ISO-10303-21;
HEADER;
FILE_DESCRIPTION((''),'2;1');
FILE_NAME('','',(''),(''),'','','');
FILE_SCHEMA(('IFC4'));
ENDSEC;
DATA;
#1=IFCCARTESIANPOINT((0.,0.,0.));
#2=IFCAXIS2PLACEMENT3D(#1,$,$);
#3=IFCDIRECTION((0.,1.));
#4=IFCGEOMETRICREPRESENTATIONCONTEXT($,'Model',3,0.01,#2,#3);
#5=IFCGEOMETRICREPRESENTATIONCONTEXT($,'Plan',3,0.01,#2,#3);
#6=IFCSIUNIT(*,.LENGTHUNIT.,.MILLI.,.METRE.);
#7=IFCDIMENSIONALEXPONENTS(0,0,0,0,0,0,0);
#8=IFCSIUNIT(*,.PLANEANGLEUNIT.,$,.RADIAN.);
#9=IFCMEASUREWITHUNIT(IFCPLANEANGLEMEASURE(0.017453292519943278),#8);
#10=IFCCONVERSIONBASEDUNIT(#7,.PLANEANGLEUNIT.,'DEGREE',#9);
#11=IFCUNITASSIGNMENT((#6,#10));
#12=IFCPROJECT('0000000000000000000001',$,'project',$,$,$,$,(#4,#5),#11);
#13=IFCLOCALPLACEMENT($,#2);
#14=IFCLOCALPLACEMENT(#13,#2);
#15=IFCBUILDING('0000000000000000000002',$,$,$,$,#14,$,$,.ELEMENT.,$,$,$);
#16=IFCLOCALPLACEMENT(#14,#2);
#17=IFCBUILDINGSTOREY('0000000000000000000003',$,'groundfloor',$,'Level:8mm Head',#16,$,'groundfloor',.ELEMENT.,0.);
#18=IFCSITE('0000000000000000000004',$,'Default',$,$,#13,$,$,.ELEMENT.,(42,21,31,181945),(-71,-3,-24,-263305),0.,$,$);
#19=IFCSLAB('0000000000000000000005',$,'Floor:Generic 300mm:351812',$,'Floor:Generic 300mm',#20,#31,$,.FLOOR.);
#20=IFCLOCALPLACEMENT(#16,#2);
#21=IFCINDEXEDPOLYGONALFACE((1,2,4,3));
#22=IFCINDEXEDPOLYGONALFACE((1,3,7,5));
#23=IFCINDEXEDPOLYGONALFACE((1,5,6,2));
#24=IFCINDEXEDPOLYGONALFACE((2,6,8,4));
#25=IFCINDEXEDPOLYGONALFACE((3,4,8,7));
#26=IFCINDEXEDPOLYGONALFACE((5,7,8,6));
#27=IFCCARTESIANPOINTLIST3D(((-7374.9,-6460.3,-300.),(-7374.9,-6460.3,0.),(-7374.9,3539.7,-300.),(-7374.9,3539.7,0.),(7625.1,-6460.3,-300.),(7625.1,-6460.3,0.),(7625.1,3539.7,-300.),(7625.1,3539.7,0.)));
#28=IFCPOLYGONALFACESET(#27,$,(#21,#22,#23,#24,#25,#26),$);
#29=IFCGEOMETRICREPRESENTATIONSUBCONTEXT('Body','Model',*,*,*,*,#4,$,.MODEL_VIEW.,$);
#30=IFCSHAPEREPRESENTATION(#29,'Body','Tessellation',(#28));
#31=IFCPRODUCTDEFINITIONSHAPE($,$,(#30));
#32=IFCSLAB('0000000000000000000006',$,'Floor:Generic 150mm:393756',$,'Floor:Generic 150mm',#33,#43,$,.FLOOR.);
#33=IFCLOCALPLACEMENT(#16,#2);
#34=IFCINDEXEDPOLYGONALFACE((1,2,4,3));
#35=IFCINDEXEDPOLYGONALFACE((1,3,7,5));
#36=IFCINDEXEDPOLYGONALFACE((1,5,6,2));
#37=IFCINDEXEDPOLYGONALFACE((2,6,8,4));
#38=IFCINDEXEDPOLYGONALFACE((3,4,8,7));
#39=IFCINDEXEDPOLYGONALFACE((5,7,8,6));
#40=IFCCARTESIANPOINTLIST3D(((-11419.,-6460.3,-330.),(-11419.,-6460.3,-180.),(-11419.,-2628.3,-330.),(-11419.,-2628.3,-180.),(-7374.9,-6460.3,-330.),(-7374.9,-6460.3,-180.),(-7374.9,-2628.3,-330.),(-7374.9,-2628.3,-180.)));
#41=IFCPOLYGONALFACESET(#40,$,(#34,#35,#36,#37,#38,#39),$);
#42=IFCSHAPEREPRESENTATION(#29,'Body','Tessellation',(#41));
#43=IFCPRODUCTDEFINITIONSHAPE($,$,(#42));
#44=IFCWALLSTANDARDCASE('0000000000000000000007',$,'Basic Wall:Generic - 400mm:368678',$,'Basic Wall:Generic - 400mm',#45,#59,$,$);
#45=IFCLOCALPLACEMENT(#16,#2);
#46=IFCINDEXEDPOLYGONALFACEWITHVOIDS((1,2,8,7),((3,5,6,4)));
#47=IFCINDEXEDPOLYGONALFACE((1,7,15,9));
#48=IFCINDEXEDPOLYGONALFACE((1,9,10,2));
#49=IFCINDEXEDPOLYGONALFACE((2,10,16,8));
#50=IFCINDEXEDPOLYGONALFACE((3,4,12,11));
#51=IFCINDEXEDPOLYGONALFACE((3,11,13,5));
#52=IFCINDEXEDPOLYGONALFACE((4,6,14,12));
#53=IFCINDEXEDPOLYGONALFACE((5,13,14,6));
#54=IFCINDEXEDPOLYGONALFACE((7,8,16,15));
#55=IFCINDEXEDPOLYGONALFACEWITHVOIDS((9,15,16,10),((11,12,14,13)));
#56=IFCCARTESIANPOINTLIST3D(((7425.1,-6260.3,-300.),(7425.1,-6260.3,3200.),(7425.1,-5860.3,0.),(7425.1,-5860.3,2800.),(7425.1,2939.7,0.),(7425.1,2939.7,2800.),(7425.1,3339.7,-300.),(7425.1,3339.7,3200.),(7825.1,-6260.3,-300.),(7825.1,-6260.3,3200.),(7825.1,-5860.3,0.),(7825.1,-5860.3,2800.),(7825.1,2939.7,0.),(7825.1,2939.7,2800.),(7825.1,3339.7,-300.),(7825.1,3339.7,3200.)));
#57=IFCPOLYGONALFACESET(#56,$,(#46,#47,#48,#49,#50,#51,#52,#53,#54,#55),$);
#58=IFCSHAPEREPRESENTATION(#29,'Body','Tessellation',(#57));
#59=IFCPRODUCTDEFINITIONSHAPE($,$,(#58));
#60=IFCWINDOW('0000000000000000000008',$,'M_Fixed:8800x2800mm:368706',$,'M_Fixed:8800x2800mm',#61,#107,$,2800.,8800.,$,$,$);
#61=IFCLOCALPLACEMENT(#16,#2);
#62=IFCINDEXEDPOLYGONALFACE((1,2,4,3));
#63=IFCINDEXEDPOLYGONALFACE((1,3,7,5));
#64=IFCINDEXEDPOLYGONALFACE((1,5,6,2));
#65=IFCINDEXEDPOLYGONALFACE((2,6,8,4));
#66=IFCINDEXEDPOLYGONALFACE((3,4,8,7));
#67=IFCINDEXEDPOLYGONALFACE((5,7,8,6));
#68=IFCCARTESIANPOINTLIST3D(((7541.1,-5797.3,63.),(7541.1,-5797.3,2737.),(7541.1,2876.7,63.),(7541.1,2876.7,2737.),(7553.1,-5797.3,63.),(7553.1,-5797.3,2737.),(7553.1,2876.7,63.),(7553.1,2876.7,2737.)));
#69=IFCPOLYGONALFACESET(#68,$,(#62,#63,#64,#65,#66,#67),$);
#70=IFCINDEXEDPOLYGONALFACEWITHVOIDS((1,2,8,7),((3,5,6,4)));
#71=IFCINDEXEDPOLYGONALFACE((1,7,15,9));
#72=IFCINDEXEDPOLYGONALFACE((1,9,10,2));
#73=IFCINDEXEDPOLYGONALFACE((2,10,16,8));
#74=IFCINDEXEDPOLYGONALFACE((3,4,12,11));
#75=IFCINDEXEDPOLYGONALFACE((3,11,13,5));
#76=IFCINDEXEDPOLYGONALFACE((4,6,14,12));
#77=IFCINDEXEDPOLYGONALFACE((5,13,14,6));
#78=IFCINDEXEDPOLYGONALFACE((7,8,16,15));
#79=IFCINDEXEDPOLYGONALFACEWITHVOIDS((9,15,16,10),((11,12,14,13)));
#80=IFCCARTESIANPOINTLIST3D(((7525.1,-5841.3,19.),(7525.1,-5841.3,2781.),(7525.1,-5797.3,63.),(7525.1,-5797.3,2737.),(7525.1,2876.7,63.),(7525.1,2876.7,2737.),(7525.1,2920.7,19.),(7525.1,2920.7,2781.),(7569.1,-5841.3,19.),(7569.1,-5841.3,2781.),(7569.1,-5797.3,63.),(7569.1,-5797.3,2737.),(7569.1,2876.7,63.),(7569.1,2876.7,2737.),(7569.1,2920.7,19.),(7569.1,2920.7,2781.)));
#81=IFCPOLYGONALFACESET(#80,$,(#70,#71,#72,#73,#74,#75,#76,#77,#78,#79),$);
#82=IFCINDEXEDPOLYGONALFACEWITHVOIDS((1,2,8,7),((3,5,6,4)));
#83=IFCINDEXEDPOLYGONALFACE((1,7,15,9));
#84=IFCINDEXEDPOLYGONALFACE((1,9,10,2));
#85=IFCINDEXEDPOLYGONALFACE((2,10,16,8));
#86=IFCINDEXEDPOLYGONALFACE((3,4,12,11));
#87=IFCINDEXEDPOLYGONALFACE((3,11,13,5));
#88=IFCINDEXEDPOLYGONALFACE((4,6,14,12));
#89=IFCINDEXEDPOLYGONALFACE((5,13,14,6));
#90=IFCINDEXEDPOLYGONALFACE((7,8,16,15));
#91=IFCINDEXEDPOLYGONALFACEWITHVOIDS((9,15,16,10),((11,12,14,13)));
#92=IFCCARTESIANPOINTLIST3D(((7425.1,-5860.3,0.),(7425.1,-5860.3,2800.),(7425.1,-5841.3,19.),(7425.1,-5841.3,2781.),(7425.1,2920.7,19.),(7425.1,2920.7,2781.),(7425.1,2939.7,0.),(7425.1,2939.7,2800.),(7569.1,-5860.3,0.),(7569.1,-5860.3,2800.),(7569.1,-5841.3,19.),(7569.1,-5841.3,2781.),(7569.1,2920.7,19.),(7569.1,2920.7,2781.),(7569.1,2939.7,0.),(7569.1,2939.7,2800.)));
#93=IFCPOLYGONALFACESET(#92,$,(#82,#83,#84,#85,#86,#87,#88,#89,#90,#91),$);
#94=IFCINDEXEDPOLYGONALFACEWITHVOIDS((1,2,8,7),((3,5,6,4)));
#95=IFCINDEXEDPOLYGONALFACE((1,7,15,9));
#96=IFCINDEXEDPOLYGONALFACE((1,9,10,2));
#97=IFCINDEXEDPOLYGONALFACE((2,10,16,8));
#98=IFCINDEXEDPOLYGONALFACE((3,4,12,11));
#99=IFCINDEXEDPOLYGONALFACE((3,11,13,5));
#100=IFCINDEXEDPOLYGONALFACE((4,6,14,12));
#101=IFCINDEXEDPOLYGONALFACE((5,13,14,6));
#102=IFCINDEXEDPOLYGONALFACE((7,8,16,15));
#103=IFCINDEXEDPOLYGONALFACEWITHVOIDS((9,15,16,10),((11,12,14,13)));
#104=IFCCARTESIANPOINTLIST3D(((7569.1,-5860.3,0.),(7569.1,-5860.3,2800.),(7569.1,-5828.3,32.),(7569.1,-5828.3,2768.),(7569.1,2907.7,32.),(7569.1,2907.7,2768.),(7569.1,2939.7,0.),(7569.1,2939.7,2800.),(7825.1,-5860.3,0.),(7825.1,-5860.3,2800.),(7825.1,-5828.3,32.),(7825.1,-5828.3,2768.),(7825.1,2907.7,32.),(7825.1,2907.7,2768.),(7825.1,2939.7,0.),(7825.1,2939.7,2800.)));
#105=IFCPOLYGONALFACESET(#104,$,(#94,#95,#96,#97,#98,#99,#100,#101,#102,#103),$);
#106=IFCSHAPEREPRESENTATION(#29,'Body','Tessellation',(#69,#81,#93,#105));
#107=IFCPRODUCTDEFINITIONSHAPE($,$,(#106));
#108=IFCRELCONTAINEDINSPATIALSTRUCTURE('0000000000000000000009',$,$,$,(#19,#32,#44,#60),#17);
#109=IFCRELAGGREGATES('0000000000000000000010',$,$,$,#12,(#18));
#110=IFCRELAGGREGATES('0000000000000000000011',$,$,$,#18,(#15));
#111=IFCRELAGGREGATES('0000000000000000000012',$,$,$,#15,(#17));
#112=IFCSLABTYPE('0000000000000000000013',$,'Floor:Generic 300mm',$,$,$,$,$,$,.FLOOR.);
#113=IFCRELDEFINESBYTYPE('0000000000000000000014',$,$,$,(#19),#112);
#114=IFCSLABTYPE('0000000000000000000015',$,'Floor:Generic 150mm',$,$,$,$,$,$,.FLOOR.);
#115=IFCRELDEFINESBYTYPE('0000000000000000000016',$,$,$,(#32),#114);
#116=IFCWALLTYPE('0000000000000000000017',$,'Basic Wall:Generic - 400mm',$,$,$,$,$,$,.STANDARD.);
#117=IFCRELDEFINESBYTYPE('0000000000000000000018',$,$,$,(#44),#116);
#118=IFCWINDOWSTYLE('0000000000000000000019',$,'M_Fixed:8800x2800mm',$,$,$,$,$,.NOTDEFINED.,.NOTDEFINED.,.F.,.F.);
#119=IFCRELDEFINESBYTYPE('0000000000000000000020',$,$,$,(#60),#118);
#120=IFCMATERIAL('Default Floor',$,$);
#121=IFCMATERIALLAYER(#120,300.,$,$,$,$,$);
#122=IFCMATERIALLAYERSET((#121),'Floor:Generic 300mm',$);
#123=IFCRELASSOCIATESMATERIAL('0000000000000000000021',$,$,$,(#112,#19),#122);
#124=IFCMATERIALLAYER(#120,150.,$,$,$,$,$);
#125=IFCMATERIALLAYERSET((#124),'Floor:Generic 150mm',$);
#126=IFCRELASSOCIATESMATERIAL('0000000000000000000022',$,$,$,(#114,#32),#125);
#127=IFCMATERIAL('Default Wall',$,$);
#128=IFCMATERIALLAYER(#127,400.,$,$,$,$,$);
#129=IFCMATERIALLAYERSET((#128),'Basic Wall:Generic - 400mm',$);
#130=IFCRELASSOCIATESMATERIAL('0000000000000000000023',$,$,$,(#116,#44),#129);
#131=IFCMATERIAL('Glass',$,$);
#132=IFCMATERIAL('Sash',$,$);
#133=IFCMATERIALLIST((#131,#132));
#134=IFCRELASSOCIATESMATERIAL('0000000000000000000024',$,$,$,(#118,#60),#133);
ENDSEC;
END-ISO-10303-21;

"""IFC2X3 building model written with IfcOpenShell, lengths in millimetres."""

from ifc_helpers import new_model, entity, si_unit, converted_unit, direction, frame, frame_2d, origin, origin_2d_with_axis, place, context, subcontext, project, spatial, polyline, rectangle, outline, extrude, source, transform, mapped, material, material_list, layer, layer_set, layer_usage, type_object, type_shapes, element, fill, save


model = new_model("IFC2X3")

# Units and contexts
model_context = context("Model", 3, precision=0.01, world=origin(), true_north=direction((0.0, 1.0)))
plan_context = context("Plan", 3, precision=0.01, world=origin(), true_north=direction((0.0, 1.0)))
body_context = subcontext(model_context, "Body", "Model", "MODEL_VIEW")
ifc_project = project(units=[si_unit("LENGTHUNIT", "METRE", prefix="MILLI"), converted_unit("PLANEANGLEUNIT", "DEGREE", entity("IfcPlaneAngleMeasure", 0.017453292519943278), si_unit("PLANEANGLEUNIT", "RADIAN"), dimensions=[0, 0, 0, 0, 0, 0, 0])], contexts=[model_context, plan_context])

# Site, building, storey
site_placement = place(None, origin())
site = spatial("IfcSite", under=ifc_project, at=site_placement, Name="Default", CompositionType="ELEMENT", RefLatitude=(42, 21, 31, 181945), RefLongitude=(-71, -3, -24, -263305), RefElevation=0.0)
building_placement = place(site_placement, origin())
building = spatial("IfcBuilding", under=site, at=building_placement, CompositionType="ELEMENT")
storey_placement = place(building_placement, origin())
storey = spatial("IfcBuildingStorey", under=building, at=storey_placement, Name="groundfloor", ObjectType="Level:8mm Head", LongName="groundfloor", CompositionType="ELEMENT", Elevation=0.0)

# Slabs
ifc_material_1 = material(Name="Default Floor")
ifc_layer_1 = layer(ifc_material_1, 300.0)
ifc_layer_set_1 = layer_set([ifc_layer_1], Name="Floor:Generic 300mm")
ifc_layer_usage_1 = layer_usage(ifc_layer_set_1, "AXIS3", "POSITIVE", 0.0)
slab_type_1 = type_object("IfcSlabType", Name="Floor:Generic 300mm", PredefinedType="FLOOR", material=ifc_layer_set_1)
slab_1_placement = place(storey_placement, origin())
element("IfcSlab", 1, at=slab_1_placement, inside=storey, type_object=slab_type_1, material=ifc_layer_usage_1, Name="Floor:Generic 300mm:351812", ObjectType="Floor:Generic 300mm", PredefinedType="FLOOR", context=body_context, shape_type="SweptSolid", body=[
    extrude(rectangle(XDim=10000.0, YDim=15000.0, at=origin_2d_with_axis()), frame((125.1, -1460.3, 0.0), z_axis=(0.0, 0.0, -1.0), x_axis=(0.0, 1.0, 0.0)), (0.0, 0.0, 1.0), 300.0),
])
ifc_layer_2 = layer(ifc_material_1, 150.0)
ifc_layer_set_2 = layer_set([ifc_layer_2], Name="Floor:Generic 150mm")
ifc_layer_usage_2 = layer_usage(ifc_layer_set_2, "AXIS3", "POSITIVE", 0.0)
slab_type_2 = type_object("IfcSlabType", Name="Floor:Generic 150mm", PredefinedType="FLOOR", material=ifc_layer_set_2)
slab_2_placement = place(storey_placement, origin())
element("IfcSlab", 2, at=slab_2_placement, inside=storey, type_object=slab_type_2, material=ifc_layer_usage_2, Name="Floor:Generic 150mm:393756", ObjectType="Floor:Generic 150mm", PredefinedType="FLOOR", context=body_context, shape_type="SweptSolid", body=[
    extrude(rectangle(XDim=3832.0, YDim=4044.0, at=frame_2d((0.0, 0.0), x_axis=(1.0, 0.0))), frame((-9397.0, -4544.3, -180.0), z_axis=(0.0, 0.0, -1.0), x_axis=(0.0, 1.0, 0.0)), (0.0, 0.0, 1.0), 150.0),
])

# Wall, openings, window
ifc_material_2 = material(Name="Default Wall")
ifc_layer_3 = layer(ifc_material_2, 400.0)
ifc_layer_set_3 = layer_set([ifc_layer_3], Name="Basic Wall:Generic - 400mm")
ifc_layer_usage_3 = layer_usage(ifc_layer_set_3, "AXIS2", "NEGATIVE", 200.0)
wall_type_1 = type_object("IfcWallType", Name="Basic Wall:Generic - 400mm", PredefinedType="STANDARD", material=ifc_layer_set_3)
wall_1_placement = place(storey_placement, frame((7625.1, 3339.7, -300.0), z_axis=(0.0, 0.0, 1.0), x_axis=(0.0, -1.0, 0.0)))
wall_1 = element("IfcWallStandardCase", 3, at=wall_1_placement, inside=storey, type_object=wall_type_1, material=ifc_layer_usage_3, Name="Basic Wall:Generic - 400mm:368678", ObjectType="Basic Wall:Generic - 400mm", context=body_context, shape_type="SweptSolid", body=[
    extrude(rectangle(XDim=9600.0, YDim=400.0, at=frame_2d((4800.0, 0.0), x_axis=(-1.0, 0.0))), origin(), (0.0, 0.0, 1.0), 3500.0),
])
opening_1_placement = place(wall_1_placement, frame((3339.7, -7625.1, 3500.0)))
element("IfcOpeningElement", 4, at=opening_1_placement, cuts=wall_1, ObjectType="Opening", context=body_context, shape_type="SweptSolid", body=[
    extrude(rectangle(XDim=2500.0, YDim=1000.0, at=frame_2d((0.0, 0.0), x_axis=(0.0, 1.0))), frame((-2039.7, 6301.1, 1250.0), z_axis=(0.0, 1.0, 0.0), x_axis=(-1.0, 0.0, 0.0)), (0.0, 0.0, 1.0), 3048.0),
])
opening_2_placement = place(wall_1_placement, frame((3339.7, -7625.1, 3500.0)))
element("IfcOpeningElement", 5, at=opening_2_placement, cuts=wall_1, ObjectType="Opening", context=body_context, shape_type="SweptSolid", body=[
    extrude(rectangle(XDim=2500.0, YDim=1000.0, at=frame_2d((0.0, 0.0), x_axis=(1.0, 0.0))), frame((-639.7, 6301.1, 1250.0), z_axis=(0.0, 1.0, 0.0), x_axis=(0.0, 0.0, 1.0)), (0.0, 0.0, 1.0), 3048.0),
])
opening_3_placement = place(wall_1_placement, frame((3339.7, -7625.1, 3500.0)))
element("IfcOpeningElement", 6, at=opening_3_placement, cuts=wall_1, ObjectType="Opening", context=body_context, shape_type="SweptSolid", body=[
    extrude(rectangle(XDim=2500.0, YDim=1000.0, at=frame_2d((0.0, 0.0), x_axis=(1.0, 0.0))), frame((760.3, 6301.1, 1250.0), z_axis=(0.0, 1.0, 0.0), x_axis=(0.0, 0.0, 1.0)), (0.0, 0.0, 1.0), 3048.0),
])
opening_4_placement = place(wall_1_placement, frame((3339.7, -7625.1, 3500.0)))
element("IfcOpeningElement", 7, at=opening_4_placement, cuts=wall_1, ObjectType="Opening", context=body_context, shape_type="SweptSolid", body=[
    extrude(rectangle(XDim=2500.0, YDim=1000.0, at=frame_2d((0.0, 0.0), x_axis=(1.0, 0.0))), frame((2160.3, 6301.1, 1250.0), z_axis=(0.0, 1.0, 0.0), x_axis=(0.0, 0.0, 1.0)), (0.0, 0.0, 1.0), 3048.0),
])
opening_5_placement = place(wall_1_placement, frame((3339.7, -7625.1, 3500.0)))
element("IfcOpeningElement", 8, at=opening_5_placement, cuts=wall_1, ObjectType="Opening", context=body_context, shape_type="SweptSolid", body=[
    extrude(rectangle(XDim=2500.0, YDim=1000.0, at=frame_2d((0.0, 0.0), x_axis=(1.0, 0.0))), frame((3560.3, 6301.1, 1250.0), z_axis=(0.0, 1.0, 0.0), x_axis=(0.0, 0.0, 1.0)), (0.0, 0.0, 1.0), 3048.0),
])
opening_6_placement = place(wall_1_placement, frame((3339.7, -7625.1, 3500.0)))
element("IfcOpeningElement", 9, at=opening_6_placement, cuts=wall_1, ObjectType="Opening", context=body_context, shape_type="SweptSolid", body=[
    extrude(rectangle(XDim=2500.0, YDim=1000.0, at=frame_2d((0.0, 0.0), x_axis=(1.0, 0.0))), frame((4960.3, 6301.1, 1250.0), z_axis=(0.0, 1.0, 0.0), x_axis=(0.0, 0.0, 1.0)), (0.0, 0.0, 1.0), 3048.0),
])
opening_7_placement = place(wall_1_placement, frame((9200.0, 200.0, 300.0)))
opening_7 = element("IfcOpeningElement", 10, at=opening_7_placement, cuts=wall_1, ObjectType="Opening", context=body_context, shape_type="SweptSolid", body=[
    extrude(rectangle(XDim=2800.0, YDim=8800.0, at=frame_2d((1400.0, 4400.0), x_axis=(1.0, 0.0))), frame((0.0, 0.0, 0.0), z_axis=(0.0, -1.0, 0.0), x_axis=(0.0, 0.0, 1.0)), (0.0, 0.0, 1.0), 400.0),
])
ifc_material_3 = material(Name="Glass")
ifc_material_4 = material(Name="Sash")
ifc_material_list_1 = material_list([ifc_material_3, ifc_material_4])
window_style_1 = type_object("IfcWindowStyle", Name="M_Fixed:8800x2800mm", ConstructionType="NOTDEFINED", OperationType="NOTDEFINED", ParameterTakesPrecedence=False, Sizeable=False, material=ifc_material_list_1)
shared_shape_1 = source(origin(), body_context, "Body", "SweptSolid", [
    extrude(rectangle(XDim=8674.0, YDim=12.0, at=frame_2d((0.0, 0.0), x_axis=(1.0, 0.0))), frame((4400.0, 304.0, 63.0), z_axis=(0.0, 0.0, 1.0), x_axis=(-1.0, 0.0, 0.0)), (0.0, 0.0, 1.0), 2674.0),
    extrude(outline(polyline([(-4381.0, -1381.0), (4381.0, -1381.0), (4381.0, 1381.0), (-4381.0, 1381.0), (-4381.0, -1381.0)]), holes=[polyline([(-4337.0, -1337.0), (-4337.0, 1337.0), (4337.0, 1337.0), (4337.0, -1337.0), (-4337.0, -1337.0)])]), frame((4400.0, 326.0, 1400.0), z_axis=(0.0, -1.0, 0.0), x_axis=(-1.0, 0.0, 0.0)), (0.0, 0.0, 1.0), 44.0),
    extrude(outline(polyline([(-4400.0, -1400.0), (4400.0, -1400.0), (4400.0, 1400.0), (-4400.0, 1400.0), (-4400.0, -1400.0)]), holes=[polyline([(-4381.0, -1381.0), (-4381.0, 1381.0), (4381.0, 1381.0), (4381.0, -1381.0), (-4381.0, -1381.0)])]), frame((4400.0, 426.0, 1400.0), z_axis=(0.0, -1.0, 0.0), x_axis=(-1.0, 0.0, 0.0)), (0.0, 0.0, 1.0), 144.0),
    extrude(outline(polyline([(-4400.0, -1400.0), (4400.0, -1400.0), (4400.0, 1400.0), (-4400.0, 1400.0), (-4400.0, -1400.0)]), holes=[polyline([(-4368.0, -1368.0), (-4368.0, 1368.0), (4368.0, 1368.0), (4368.0, -1368.0), (-4368.0, -1368.0)])]), frame((4400.0, 282.0, 1400.0), z_axis=(0.0, -1.0, 0.0), x_axis=(-1.0, 0.0, 0.0)), (0.0, 0.0, 1.0), 256.0),
])
type_shapes(window_style_1, [shared_shape_1])
window_1_placement = place(opening_7_placement, frame((0.0, 26.0, 0.0), z_axis=(0.0, 0.0, 1.0), x_axis=(-1.0, 0.0, 0.0)))
window_1 = element("IfcWindow", 11, at=window_1_placement, inside=storey, type_object=window_style_1, material=ifc_material_list_1, Name="M_Fixed:8800x2800mm:368706", ObjectType="M_Fixed:8800x2800mm", OverallHeight=2800.0, OverallWidth=8800.0, context=body_context, shape_type="MappedRepresentation", body=[
    mapped(shared_shape_1, transform((0.0, 0.0, 0.0), scale=1.0)),
])
fill(opening_7, window_1)

save(model, "model.ifc")
